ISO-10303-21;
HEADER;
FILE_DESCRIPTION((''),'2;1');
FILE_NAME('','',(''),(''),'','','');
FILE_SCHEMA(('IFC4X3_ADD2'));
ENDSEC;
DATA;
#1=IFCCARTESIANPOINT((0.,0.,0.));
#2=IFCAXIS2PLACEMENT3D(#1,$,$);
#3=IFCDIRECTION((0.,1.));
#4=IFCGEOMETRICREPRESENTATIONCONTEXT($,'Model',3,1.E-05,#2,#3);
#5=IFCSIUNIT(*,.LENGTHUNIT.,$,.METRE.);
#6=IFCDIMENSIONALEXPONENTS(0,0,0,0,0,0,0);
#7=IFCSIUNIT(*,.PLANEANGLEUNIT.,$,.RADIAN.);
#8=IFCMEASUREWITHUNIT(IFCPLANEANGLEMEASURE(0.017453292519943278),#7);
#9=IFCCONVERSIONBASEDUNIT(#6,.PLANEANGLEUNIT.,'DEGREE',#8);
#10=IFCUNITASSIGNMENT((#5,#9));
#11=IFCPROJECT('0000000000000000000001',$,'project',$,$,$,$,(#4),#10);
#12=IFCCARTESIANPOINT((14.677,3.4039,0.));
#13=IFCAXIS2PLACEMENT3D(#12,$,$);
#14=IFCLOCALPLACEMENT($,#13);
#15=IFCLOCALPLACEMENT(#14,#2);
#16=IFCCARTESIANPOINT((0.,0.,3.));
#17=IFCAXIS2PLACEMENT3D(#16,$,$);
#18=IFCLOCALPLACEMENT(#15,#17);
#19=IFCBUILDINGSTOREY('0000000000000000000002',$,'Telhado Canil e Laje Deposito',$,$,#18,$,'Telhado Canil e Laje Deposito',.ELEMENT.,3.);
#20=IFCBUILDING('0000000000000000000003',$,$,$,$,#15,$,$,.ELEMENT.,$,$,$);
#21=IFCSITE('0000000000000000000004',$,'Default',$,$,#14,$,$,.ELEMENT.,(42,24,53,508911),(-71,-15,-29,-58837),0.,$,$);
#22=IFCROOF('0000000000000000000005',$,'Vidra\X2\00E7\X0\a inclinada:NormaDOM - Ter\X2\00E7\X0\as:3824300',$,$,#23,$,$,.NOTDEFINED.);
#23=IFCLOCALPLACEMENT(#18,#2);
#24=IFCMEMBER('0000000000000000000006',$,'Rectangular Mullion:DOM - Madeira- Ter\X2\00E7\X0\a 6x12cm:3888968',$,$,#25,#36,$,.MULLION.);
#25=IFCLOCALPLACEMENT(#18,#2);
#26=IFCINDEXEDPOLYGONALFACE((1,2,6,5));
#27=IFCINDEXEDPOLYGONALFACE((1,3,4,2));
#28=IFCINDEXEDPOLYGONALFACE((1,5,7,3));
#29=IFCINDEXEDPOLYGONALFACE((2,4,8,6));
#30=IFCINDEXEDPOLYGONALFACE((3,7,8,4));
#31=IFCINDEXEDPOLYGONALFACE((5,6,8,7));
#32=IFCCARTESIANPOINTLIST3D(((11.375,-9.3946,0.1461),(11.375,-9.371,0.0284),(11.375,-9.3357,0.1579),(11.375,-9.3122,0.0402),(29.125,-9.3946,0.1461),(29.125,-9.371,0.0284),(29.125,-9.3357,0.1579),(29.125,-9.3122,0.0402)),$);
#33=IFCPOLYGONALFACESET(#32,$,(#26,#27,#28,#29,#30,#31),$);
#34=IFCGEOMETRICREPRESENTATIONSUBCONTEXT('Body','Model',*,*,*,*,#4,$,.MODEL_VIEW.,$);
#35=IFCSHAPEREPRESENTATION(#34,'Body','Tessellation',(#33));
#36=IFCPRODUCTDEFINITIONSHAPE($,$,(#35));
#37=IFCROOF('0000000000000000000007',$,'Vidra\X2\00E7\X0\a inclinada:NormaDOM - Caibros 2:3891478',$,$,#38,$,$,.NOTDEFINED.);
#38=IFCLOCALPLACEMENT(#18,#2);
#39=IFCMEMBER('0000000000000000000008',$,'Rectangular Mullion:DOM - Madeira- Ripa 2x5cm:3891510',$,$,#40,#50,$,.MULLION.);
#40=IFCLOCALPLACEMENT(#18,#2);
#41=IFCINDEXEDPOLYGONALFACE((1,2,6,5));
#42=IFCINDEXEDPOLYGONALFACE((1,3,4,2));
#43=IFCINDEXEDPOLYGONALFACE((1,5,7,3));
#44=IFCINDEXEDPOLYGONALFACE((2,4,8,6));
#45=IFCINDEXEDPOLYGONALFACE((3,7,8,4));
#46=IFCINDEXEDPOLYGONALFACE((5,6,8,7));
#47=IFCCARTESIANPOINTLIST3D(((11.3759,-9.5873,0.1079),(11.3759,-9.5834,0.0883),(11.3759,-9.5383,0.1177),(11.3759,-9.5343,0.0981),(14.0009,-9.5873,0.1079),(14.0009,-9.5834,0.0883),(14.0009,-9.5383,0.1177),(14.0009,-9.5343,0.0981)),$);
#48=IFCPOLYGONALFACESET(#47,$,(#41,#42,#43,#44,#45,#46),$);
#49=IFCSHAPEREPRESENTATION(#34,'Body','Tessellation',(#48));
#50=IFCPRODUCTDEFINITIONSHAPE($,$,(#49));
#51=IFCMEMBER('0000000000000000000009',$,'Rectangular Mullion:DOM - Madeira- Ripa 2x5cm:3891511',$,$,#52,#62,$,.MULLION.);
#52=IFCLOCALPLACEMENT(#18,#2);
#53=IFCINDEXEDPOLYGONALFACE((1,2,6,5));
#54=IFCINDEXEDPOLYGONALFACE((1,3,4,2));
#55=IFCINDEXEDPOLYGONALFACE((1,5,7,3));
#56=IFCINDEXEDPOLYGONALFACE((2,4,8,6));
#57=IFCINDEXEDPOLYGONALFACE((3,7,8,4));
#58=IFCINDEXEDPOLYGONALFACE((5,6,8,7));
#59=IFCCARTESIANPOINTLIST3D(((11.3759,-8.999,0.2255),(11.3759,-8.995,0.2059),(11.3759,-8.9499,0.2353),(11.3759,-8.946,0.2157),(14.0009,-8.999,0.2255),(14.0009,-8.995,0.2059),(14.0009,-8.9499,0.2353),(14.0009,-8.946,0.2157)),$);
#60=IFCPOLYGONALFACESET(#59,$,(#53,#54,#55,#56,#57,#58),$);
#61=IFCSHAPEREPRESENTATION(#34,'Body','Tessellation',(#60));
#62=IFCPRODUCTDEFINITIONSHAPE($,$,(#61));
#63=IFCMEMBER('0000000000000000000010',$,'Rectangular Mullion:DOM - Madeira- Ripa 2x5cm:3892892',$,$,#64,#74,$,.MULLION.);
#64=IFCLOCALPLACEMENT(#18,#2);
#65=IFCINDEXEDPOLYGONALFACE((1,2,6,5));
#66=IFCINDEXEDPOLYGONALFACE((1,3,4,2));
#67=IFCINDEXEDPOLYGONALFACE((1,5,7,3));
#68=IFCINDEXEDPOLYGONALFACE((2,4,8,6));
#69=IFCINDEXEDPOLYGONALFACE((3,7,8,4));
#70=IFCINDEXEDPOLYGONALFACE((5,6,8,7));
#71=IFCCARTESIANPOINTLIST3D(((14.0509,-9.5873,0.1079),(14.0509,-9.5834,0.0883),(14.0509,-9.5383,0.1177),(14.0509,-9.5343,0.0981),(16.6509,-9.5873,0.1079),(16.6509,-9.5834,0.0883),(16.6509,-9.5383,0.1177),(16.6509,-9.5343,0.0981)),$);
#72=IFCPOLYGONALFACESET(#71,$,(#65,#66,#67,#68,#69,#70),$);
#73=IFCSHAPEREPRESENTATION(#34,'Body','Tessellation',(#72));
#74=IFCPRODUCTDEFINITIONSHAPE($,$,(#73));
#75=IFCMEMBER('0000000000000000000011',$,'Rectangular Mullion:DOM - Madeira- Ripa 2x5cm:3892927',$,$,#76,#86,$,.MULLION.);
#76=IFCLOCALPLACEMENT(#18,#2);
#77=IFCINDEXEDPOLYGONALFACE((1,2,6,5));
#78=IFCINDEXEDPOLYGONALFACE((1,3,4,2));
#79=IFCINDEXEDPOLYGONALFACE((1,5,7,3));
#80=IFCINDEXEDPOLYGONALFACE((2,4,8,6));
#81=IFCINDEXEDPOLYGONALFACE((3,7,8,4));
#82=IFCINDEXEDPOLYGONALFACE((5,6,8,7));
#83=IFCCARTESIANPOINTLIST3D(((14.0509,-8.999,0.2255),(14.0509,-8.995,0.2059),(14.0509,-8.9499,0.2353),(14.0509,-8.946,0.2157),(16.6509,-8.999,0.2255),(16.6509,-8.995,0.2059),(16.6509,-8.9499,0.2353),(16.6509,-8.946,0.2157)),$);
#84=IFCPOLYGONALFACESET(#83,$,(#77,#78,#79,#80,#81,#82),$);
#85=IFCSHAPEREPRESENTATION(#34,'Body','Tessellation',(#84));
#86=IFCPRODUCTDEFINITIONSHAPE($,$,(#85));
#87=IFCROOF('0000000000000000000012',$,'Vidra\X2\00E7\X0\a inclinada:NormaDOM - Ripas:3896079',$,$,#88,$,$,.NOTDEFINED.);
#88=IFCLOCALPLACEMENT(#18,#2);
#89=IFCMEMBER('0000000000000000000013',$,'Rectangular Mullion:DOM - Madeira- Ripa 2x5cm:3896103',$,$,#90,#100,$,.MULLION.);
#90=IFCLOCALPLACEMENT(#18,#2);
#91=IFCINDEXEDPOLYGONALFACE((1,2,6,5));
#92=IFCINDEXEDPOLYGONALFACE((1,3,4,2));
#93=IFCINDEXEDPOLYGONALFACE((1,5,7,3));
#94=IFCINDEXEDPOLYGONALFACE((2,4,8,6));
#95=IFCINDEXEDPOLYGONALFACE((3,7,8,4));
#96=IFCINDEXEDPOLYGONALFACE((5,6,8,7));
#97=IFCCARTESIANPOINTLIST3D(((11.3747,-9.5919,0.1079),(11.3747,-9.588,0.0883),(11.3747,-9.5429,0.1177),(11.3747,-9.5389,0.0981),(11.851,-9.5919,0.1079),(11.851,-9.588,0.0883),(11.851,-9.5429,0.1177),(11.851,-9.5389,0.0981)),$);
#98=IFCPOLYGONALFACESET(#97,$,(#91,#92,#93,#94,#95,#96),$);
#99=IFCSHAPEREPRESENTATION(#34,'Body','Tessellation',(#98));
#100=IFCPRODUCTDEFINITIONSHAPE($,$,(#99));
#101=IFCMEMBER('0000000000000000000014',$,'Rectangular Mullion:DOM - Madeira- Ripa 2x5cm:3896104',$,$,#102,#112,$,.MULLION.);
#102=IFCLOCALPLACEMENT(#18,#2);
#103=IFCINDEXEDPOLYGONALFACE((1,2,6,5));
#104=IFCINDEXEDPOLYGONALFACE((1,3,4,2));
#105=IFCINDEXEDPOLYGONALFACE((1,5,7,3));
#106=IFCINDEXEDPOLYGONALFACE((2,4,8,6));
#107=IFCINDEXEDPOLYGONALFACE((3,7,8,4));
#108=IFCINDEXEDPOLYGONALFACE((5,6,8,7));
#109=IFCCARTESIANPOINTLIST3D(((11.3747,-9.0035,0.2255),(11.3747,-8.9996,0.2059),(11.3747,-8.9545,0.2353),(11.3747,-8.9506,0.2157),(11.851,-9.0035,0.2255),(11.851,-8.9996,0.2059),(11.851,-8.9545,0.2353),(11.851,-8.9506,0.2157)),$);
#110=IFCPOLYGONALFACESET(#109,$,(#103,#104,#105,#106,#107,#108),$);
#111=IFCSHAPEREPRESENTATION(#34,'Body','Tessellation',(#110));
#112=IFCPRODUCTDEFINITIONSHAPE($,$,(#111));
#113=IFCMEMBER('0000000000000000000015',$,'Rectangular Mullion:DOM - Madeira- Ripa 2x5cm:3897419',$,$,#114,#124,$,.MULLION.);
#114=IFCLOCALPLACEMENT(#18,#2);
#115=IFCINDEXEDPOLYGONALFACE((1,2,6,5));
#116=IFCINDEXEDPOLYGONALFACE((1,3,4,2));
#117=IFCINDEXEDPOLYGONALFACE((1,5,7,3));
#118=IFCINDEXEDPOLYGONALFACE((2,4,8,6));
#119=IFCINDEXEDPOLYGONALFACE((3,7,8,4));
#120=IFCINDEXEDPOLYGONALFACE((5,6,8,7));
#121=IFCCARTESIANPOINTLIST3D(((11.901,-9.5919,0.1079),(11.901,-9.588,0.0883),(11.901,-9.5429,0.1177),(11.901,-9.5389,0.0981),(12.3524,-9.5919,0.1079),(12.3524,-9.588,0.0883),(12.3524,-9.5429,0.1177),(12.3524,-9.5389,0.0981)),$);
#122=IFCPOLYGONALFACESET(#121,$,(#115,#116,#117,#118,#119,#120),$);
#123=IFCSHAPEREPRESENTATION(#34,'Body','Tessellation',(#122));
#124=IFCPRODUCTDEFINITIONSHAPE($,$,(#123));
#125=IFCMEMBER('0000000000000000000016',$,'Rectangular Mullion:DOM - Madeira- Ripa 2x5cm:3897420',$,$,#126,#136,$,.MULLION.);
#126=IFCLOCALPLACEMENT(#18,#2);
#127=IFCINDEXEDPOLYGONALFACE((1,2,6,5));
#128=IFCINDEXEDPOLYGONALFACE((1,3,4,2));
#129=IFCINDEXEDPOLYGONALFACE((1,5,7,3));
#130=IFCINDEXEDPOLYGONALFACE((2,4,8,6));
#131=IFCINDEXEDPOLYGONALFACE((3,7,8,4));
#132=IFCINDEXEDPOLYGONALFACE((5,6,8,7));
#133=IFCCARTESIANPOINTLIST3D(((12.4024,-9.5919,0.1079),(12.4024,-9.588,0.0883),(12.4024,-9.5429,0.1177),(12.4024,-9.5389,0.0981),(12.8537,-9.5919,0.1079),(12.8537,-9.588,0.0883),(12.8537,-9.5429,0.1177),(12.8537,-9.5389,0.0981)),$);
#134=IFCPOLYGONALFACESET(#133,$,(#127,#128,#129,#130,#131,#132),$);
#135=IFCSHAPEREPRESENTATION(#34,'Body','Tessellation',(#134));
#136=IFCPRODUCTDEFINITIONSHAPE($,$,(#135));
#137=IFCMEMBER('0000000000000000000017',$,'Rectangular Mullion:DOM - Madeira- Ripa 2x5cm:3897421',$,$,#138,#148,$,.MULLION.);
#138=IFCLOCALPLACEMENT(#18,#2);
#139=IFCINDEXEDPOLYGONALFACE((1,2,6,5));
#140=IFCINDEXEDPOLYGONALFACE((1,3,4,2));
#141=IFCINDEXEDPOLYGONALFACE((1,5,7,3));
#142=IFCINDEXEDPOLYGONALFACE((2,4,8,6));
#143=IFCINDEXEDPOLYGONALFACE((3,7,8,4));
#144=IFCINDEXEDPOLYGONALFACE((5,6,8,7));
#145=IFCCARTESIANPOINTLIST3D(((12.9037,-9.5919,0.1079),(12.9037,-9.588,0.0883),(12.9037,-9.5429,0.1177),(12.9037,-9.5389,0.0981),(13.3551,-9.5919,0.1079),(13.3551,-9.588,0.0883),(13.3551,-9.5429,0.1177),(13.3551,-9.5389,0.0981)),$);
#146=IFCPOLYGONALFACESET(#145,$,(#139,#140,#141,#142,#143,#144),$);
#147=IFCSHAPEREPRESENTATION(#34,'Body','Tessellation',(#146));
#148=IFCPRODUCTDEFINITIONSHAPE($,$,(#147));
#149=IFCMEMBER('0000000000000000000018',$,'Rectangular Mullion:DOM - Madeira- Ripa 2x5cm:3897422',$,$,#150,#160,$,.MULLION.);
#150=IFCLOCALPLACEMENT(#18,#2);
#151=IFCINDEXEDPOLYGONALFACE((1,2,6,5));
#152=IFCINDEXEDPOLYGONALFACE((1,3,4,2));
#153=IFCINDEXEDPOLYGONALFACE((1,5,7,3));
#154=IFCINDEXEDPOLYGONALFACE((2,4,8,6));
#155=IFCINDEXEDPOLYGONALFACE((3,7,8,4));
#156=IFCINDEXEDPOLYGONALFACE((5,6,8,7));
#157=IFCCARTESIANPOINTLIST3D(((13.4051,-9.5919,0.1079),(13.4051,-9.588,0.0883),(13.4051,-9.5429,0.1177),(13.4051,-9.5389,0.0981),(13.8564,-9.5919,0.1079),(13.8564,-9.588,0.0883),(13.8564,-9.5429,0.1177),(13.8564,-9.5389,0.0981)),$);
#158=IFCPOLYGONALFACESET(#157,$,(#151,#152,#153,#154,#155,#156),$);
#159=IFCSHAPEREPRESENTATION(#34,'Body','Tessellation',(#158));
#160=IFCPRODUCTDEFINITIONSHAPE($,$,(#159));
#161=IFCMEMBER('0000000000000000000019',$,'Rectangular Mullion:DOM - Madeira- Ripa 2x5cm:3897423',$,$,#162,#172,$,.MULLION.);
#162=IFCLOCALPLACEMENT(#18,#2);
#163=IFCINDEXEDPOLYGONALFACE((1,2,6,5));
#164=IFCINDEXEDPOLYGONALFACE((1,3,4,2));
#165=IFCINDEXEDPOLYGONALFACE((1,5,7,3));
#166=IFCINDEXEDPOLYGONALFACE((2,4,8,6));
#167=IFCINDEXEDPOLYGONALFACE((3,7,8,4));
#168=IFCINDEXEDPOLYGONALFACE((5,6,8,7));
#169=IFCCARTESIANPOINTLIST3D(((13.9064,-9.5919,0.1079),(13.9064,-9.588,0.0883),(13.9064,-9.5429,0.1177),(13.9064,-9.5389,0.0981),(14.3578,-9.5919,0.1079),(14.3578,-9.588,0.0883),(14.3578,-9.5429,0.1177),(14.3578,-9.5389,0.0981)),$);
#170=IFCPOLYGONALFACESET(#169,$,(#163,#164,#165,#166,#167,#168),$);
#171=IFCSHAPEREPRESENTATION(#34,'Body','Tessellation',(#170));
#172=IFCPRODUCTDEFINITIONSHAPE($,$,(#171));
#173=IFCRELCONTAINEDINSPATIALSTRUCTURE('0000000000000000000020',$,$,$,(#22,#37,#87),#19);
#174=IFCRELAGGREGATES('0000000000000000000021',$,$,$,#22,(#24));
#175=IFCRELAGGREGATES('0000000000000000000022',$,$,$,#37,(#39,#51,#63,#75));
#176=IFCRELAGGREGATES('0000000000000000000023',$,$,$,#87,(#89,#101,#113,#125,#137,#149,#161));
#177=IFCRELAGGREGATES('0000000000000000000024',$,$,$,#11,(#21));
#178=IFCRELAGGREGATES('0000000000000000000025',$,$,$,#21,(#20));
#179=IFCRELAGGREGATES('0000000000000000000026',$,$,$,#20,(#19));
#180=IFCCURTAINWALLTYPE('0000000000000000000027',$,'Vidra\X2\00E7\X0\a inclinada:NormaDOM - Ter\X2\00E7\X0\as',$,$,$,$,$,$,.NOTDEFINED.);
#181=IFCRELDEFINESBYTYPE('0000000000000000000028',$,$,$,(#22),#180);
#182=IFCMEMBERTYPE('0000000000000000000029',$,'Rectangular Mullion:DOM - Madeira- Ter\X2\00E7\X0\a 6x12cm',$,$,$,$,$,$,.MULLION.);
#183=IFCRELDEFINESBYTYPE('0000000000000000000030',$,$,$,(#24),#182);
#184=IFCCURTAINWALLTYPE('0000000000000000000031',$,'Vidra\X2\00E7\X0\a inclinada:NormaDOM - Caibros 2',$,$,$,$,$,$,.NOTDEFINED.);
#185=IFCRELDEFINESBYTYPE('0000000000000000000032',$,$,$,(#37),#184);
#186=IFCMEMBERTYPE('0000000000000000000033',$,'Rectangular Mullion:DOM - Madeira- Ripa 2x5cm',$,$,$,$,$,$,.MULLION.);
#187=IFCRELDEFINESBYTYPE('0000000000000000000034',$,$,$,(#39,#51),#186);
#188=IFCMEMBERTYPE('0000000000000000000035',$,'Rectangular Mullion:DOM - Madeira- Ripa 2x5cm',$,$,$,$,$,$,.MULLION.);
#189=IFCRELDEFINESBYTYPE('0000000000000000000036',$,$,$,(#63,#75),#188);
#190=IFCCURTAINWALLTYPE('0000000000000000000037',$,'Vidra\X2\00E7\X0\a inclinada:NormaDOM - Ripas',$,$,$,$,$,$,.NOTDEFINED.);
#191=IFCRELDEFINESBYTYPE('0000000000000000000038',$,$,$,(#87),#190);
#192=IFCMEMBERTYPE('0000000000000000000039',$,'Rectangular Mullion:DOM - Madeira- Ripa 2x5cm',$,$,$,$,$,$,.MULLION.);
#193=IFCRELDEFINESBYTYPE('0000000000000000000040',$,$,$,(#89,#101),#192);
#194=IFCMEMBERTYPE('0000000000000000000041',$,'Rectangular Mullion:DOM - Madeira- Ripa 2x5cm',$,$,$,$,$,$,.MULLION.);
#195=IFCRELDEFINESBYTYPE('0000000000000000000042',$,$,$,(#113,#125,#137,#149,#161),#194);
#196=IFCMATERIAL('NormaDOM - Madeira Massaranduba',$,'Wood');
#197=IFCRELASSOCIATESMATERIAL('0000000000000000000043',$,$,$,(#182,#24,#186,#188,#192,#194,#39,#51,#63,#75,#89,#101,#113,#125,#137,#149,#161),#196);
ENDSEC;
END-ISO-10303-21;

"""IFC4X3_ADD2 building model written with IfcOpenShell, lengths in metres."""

from ifc_helpers import new_model, entity, si_unit, converted_unit, direction, frame, origin, origin_2d_with_axis, place, context, subcontext, project, spatial, rectangle, extrude, source, transform, mapped, material, material_profile, profile_set, profile_usage, type_object, type_shapes, element, aggregate, save


model = new_model("IFC4X3_ADD2")

# Units and contexts
model_context = context("Model", 3, precision=1e-05, world=origin(), true_north=direction((0.0, 1.0)))
body_context = subcontext(model_context, "Body", "Model", "MODEL_VIEW")
ifc_project = project(units=[si_unit("LENGTHUNIT", "METRE"), converted_unit("PLANEANGLEUNIT", "DEGREE", entity("IfcPlaneAngleMeasure", 0.017453292519943278), si_unit("PLANEANGLEUNIT", "RADIAN"), dimensions=[0, 0, 0, 0, 0, 0, 0])], contexts=[model_context])

# Site, building, storey
site_placement = place(None, frame((14.677, 3.4039, 0.0)))
site = spatial("IfcSite", under=ifc_project, at=site_placement, Name="Default", CompositionType="ELEMENT", RefLatitude=(42, 24, 53, 508911), RefLongitude=(-71, -15, -29, -58837), RefElevation=0.0)
building_placement = place(site_placement, origin())
building = spatial("IfcBuilding", under=site, at=building_placement, CompositionType="ELEMENT")
storey_placement = place(building_placement, frame((0.0, 0.0, 3.0)))
storey = spatial("IfcBuildingStorey", under=building, at=storey_placement, Name="Telhado Canil e Laje Deposito", LongName="Telhado Canil e Laje Deposito", CompositionType="ELEMENT", Elevation=3.0)

# Roof, member
curtain_wall_type_1 = type_object("IfcCurtainWallType", Name="Vidraça inclinada:NormaDOM - Terças", PredefinedType="NOTDEFINED")
roof_1_placement = place(storey_placement, frame((0.0, 0.0, -3.0)))
roof_1 = element("IfcRoof", 1, at=roof_1_placement, inside=storey, type_object=curtain_wall_type_1, Name="Vidraça inclinada:NormaDOM - Terças:3824300", PredefinedType="NOTDEFINED")
ifc_material = material(Name="NormaDOM - Madeira Massaranduba", Category="Wood")
ifc_material_profile_1 = material_profile(ifc_material, rectangle(XDim=0.06, YDim=0.12, at=origin_2d_with_axis()), Name="DOM - Madeira- Terça 6x12cm")
ifc_profile_set_1 = profile_set([ifc_material_profile_1], Name="DOM - Madeira- Terça 6x12cm")
ifc_profile_usage_1 = profile_usage(ifc_profile_set_1)
member_type_1 = type_object("IfcMemberType", Name="Rectangular Mullion:DOM - Madeira- Terça 6x12cm", PredefinedType="MULLION", material=ifc_profile_set_1)
shared_shape_1 = source(origin(), body_context, "Body", "SweptSolid", [
    extrude(rectangle(XDim=0.06, YDim=0.12, at=origin_2d_with_axis()), frame((0.0, 0.06, -17.75), z_axis=(0.0, 0.0, 1.0), x_axis=(-1.0, 0.0, 0.0)), (0.0, 0.0, 1.0), 17.75),
])
type_shapes(member_type_1, [shared_shape_1])
member_1_placement = place(roof_1_placement, frame((11.375, -9.3652, 3.152), z_axis=(-1.0, 0.0, 0.0), x_axis=(0.0, 0.980581, 0.196116)))
member_1 = element("IfcMember", 2, at=member_1_placement, type_object=member_type_1, material=ifc_profile_usage_1, Name="Rectangular Mullion:DOM - Madeira- Terça 6x12cm:3888968", PredefinedType="MULLION", context=body_context, shape_type="MappedRepresentation", body=[
    mapped(shared_shape_1, transform((0.0, 0.0, 0.0), scale=1.0)),
])
aggregate(roof_1, [member_1])

# Roofs, members
curtain_wall_type_2 = type_object("IfcCurtainWallType", Name="Vidraça inclinada:NormaDOM - Caibros 2", PredefinedType="NOTDEFINED")
roof_2_placement = place(storey_placement, frame((0.0, 0.0, -3.0)))
roof_2 = element("IfcRoof", 3, at=roof_2_placement, inside=storey, type_object=curtain_wall_type_2, Name="Vidraça inclinada:NormaDOM - Caibros 2:3891478", PredefinedType="NOTDEFINED")
ifc_material_profile_2 = material_profile(ifc_material, rectangle(XDim=0.05, YDim=0.02, at=origin_2d_with_axis()), Name="DOM - Madeira- Ripa 2x5cm")
ifc_profile_set_2 = profile_set([ifc_material_profile_2], Name="DOM - Madeira- Ripa 2x5cm")
ifc_profile_usage_2 = profile_usage(ifc_profile_set_2)
member_type_2 = type_object("IfcMemberType", Name="Rectangular Mullion:DOM - Madeira- Ripa 2x5cm", PredefinedType="MULLION", material=ifc_profile_set_2)
shared_shape_2 = source(origin(), body_context, "Body", "SweptSolid", [
    extrude(rectangle(XDim=0.05, YDim=0.02, at=origin_2d_with_axis()), frame((0.025, 0.01, -2.625), z_axis=(0.0, 0.0, 1.0), x_axis=(-1.0, 0.0, 0.0)), (0.0, 0.0, 1.0), 2.625),
])
type_shapes(member_type_2, [shared_shape_2])
member_2_placement = place(roof_2_placement, frame((11.3759, -9.5873, 3.1079), z_axis=(-1.0, 0.0, 0.0), x_axis=(0.0, 0.980581, 0.196116)))
member_2 = element("IfcMember", 4, at=member_2_placement, type_object=member_type_2, material=ifc_profile_usage_2, Name="Rectangular Mullion:DOM - Madeira- Ripa 2x5cm:3891510", PredefinedType="MULLION", context=body_context, shape_type="MappedRepresentation", body=[
    mapped(shared_shape_2, transform((0.0, 0.0, 0.0), scale=1.0)),
])
member_3_placement = place(roof_2_placement, frame((11.3759, -8.999, 3.2255), z_axis=(-1.0, 0.0, 0.0), x_axis=(0.0, 0.980581, 0.196116)))
member_3 = element("IfcMember", 5, at=member_3_placement, type_object=member_type_2, material=ifc_profile_usage_2, Name="Rectangular Mullion:DOM - Madeira- Ripa 2x5cm:3891511", PredefinedType="MULLION", context=body_context, shape_type="MappedRepresentation", body=[
    mapped(shared_shape_2, transform((0.0, 0.0, 0.0), scale=1.0)),
])
member_type_3 = type_object("IfcMemberType", Name="Rectangular Mullion:DOM - Madeira- Ripa 2x5cm", PredefinedType="MULLION", material=ifc_profile_set_2)
shared_shape_3 = source(origin(), body_context, "Body", "SweptSolid", [
    extrude(rectangle(XDim=0.05, YDim=0.02, at=origin_2d_with_axis()), frame((0.025, 0.01, -2.6), z_axis=(0.0, 0.0, 1.0), x_axis=(-1.0, 0.0, 0.0)), (0.0, 0.0, 1.0), 2.6),
])
type_shapes(member_type_3, [shared_shape_3])
member_4_placement = place(roof_2_placement, frame((14.0509, -9.5873, 3.1079), z_axis=(-1.0, 0.0, 0.0), x_axis=(0.0, 0.980581, 0.196116)))
member_4 = element("IfcMember", 6, at=member_4_placement, type_object=member_type_3, material=ifc_profile_usage_2, Name="Rectangular Mullion:DOM - Madeira- Ripa 2x5cm:3892892", PredefinedType="MULLION", context=body_context, shape_type="MappedRepresentation", body=[
    mapped(shared_shape_3, transform((0.0, 0.0, 0.0), scale=1.0)),
])
member_5_placement = place(roof_2_placement, frame((14.0509, -8.999, 3.2255), z_axis=(-1.0, 0.0, 0.0), x_axis=(0.0, 0.980581, 0.196116)))
member_5 = element("IfcMember", 7, at=member_5_placement, type_object=member_type_3, material=ifc_profile_usage_2, Name="Rectangular Mullion:DOM - Madeira- Ripa 2x5cm:3892927", PredefinedType="MULLION", context=body_context, shape_type="MappedRepresentation", body=[
    mapped(shared_shape_3, transform((0.0, 0.0, 0.0), scale=1.0)),
])
aggregate(roof_2, [member_2, member_3, member_4, member_5])
curtain_wall_type_3 = type_object("IfcCurtainWallType", Name="Vidraça inclinada:NormaDOM - Ripas", PredefinedType="NOTDEFINED")
roof_3_placement = place(storey_placement, frame((0.0, 0.0, -3.0)))
roof_3 = element("IfcRoof", 8, at=roof_3_placement, inside=storey, type_object=curtain_wall_type_3, Name="Vidraça inclinada:NormaDOM - Ripas:3896079", PredefinedType="NOTDEFINED")
member_type_4 = type_object("IfcMemberType", Name="Rectangular Mullion:DOM - Madeira- Ripa 2x5cm", PredefinedType="MULLION", material=ifc_profile_set_2)
shared_shape_4 = source(origin(), body_context, "Body", "SweptSolid", [
    extrude(rectangle(XDim=0.05, YDim=0.02, at=origin_2d_with_axis()), frame((0.025, 0.01, -0.4764), z_axis=(0.0, 0.0, 1.0), x_axis=(-1.0, 0.0, 0.0)), (0.0, 0.0, 1.0), 0.4764),
])
type_shapes(member_type_4, [shared_shape_4])
member_6_placement = place(roof_3_placement, frame((11.3747, -9.5919, 3.1079), z_axis=(-1.0, 0.0, 0.0), x_axis=(0.0, 0.980581, 0.196116)))
member_6 = element("IfcMember", 9, at=member_6_placement, type_object=member_type_4, material=ifc_profile_usage_2, Name="Rectangular Mullion:DOM - Madeira- Ripa 2x5cm:3896103", PredefinedType="MULLION", context=body_context, shape_type="MappedRepresentation", body=[
    mapped(shared_shape_4, transform((0.0, 0.0, 0.0), scale=1.0)),
])
member_7_placement = place(roof_3_placement, frame((11.3747, -9.0035, 3.2255), z_axis=(-1.0, 0.0, 0.0), x_axis=(0.0, 0.980581, 0.196116)))
member_7 = element("IfcMember", 10, at=member_7_placement, type_object=member_type_4, material=ifc_profile_usage_2, Name="Rectangular Mullion:DOM - Madeira- Ripa 2x5cm:3896104", PredefinedType="MULLION", context=body_context, shape_type="MappedRepresentation", body=[
    mapped(shared_shape_4, transform((0.0, 0.0, 0.0), scale=1.0)),
])
member_type_5 = type_object("IfcMemberType", Name="Rectangular Mullion:DOM - Madeira- Ripa 2x5cm", PredefinedType="MULLION", material=ifc_profile_set_2)
shared_shape_5 = source(origin(), body_context, "Body", "SweptSolid", [
    extrude(rectangle(XDim=0.05, YDim=0.02, at=origin_2d_with_axis()), frame((0.025, 0.01, -0.4514), z_axis=(0.0, 0.0, 1.0), x_axis=(-1.0, 0.0, 0.0)), (0.0, 0.0, 1.0), 0.4514),
])
type_shapes(member_type_5, [shared_shape_5])
member_8_placement = place(roof_3_placement, frame((11.901, -9.5919, 3.1079), z_axis=(-1.0, 0.0, 0.0), x_axis=(0.0, 0.980581, 0.196116)))
member_8 = element("IfcMember", 11, at=member_8_placement, type_object=member_type_5, material=ifc_profile_usage_2, Name="Rectangular Mullion:DOM - Madeira- Ripa 2x5cm:3897419", PredefinedType="MULLION", context=body_context, shape_type="MappedRepresentation", body=[
    mapped(shared_shape_5, transform((0.0, 0.0, 0.0), scale=1.0)),
])
member_9_placement = place(roof_3_placement, frame((12.4024, -9.5919, 3.1079), z_axis=(-1.0, 0.0, 0.0), x_axis=(0.0, 0.980581, 0.196116)))
member_9 = element("IfcMember", 12, at=member_9_placement, type_object=member_type_5, material=ifc_profile_usage_2, Name="Rectangular Mullion:DOM - Madeira- Ripa 2x5cm:3897420", PredefinedType="MULLION", context=body_context, shape_type="MappedRepresentation", body=[
    mapped(shared_shape_5, transform((0.0, 0.0, 0.0), scale=1.0)),
])
member_10_placement = place(roof_3_placement, frame((12.9037, -9.5919, 3.1079), z_axis=(-1.0, 0.0, 0.0), x_axis=(0.0, 0.980581, 0.196116)))
member_10 = element("IfcMember", 13, at=member_10_placement, type_object=member_type_5, material=ifc_profile_usage_2, Name="Rectangular Mullion:DOM - Madeira- Ripa 2x5cm:3897421", PredefinedType="MULLION", context=body_context, shape_type="MappedRepresentation", body=[
    mapped(shared_shape_5, transform((0.0, 0.0, 0.0), scale=1.0)),
])
member_11_placement = place(roof_3_placement, frame((13.4051, -9.5919, 3.1079), z_axis=(-1.0, 0.0, 0.0), x_axis=(0.0, 0.980581, 0.196116)))
member_11 = element("IfcMember", 14, at=member_11_placement, type_object=member_type_5, material=ifc_profile_usage_2, Name="Rectangular Mullion:DOM - Madeira- Ripa 2x5cm:3897422", PredefinedType="MULLION", context=body_context, shape_type="MappedRepresentation", body=[
    mapped(shared_shape_5, transform((0.0, 0.0, 0.0), scale=1.0)),
])
member_12_placement = place(roof_3_placement, frame((13.9064, -9.5919, 3.1079), z_axis=(-1.0, 0.0, 0.0), x_axis=(0.0, 0.980581, 0.196116)))
member_12 = element("IfcMember", 15, at=member_12_placement, type_object=member_type_5, material=ifc_profile_usage_2, Name="Rectangular Mullion:DOM - Madeira- Ripa 2x5cm:3897423", PredefinedType="MULLION", context=body_context, shape_type="MappedRepresentation", body=[
    mapped(shared_shape_5, transform((0.0, 0.0, 0.0), scale=1.0)),
])
aggregate(roof_3, [member_6, member_7, member_8, member_9, member_10, member_11, member_12])

save(model, "model.ifc")
